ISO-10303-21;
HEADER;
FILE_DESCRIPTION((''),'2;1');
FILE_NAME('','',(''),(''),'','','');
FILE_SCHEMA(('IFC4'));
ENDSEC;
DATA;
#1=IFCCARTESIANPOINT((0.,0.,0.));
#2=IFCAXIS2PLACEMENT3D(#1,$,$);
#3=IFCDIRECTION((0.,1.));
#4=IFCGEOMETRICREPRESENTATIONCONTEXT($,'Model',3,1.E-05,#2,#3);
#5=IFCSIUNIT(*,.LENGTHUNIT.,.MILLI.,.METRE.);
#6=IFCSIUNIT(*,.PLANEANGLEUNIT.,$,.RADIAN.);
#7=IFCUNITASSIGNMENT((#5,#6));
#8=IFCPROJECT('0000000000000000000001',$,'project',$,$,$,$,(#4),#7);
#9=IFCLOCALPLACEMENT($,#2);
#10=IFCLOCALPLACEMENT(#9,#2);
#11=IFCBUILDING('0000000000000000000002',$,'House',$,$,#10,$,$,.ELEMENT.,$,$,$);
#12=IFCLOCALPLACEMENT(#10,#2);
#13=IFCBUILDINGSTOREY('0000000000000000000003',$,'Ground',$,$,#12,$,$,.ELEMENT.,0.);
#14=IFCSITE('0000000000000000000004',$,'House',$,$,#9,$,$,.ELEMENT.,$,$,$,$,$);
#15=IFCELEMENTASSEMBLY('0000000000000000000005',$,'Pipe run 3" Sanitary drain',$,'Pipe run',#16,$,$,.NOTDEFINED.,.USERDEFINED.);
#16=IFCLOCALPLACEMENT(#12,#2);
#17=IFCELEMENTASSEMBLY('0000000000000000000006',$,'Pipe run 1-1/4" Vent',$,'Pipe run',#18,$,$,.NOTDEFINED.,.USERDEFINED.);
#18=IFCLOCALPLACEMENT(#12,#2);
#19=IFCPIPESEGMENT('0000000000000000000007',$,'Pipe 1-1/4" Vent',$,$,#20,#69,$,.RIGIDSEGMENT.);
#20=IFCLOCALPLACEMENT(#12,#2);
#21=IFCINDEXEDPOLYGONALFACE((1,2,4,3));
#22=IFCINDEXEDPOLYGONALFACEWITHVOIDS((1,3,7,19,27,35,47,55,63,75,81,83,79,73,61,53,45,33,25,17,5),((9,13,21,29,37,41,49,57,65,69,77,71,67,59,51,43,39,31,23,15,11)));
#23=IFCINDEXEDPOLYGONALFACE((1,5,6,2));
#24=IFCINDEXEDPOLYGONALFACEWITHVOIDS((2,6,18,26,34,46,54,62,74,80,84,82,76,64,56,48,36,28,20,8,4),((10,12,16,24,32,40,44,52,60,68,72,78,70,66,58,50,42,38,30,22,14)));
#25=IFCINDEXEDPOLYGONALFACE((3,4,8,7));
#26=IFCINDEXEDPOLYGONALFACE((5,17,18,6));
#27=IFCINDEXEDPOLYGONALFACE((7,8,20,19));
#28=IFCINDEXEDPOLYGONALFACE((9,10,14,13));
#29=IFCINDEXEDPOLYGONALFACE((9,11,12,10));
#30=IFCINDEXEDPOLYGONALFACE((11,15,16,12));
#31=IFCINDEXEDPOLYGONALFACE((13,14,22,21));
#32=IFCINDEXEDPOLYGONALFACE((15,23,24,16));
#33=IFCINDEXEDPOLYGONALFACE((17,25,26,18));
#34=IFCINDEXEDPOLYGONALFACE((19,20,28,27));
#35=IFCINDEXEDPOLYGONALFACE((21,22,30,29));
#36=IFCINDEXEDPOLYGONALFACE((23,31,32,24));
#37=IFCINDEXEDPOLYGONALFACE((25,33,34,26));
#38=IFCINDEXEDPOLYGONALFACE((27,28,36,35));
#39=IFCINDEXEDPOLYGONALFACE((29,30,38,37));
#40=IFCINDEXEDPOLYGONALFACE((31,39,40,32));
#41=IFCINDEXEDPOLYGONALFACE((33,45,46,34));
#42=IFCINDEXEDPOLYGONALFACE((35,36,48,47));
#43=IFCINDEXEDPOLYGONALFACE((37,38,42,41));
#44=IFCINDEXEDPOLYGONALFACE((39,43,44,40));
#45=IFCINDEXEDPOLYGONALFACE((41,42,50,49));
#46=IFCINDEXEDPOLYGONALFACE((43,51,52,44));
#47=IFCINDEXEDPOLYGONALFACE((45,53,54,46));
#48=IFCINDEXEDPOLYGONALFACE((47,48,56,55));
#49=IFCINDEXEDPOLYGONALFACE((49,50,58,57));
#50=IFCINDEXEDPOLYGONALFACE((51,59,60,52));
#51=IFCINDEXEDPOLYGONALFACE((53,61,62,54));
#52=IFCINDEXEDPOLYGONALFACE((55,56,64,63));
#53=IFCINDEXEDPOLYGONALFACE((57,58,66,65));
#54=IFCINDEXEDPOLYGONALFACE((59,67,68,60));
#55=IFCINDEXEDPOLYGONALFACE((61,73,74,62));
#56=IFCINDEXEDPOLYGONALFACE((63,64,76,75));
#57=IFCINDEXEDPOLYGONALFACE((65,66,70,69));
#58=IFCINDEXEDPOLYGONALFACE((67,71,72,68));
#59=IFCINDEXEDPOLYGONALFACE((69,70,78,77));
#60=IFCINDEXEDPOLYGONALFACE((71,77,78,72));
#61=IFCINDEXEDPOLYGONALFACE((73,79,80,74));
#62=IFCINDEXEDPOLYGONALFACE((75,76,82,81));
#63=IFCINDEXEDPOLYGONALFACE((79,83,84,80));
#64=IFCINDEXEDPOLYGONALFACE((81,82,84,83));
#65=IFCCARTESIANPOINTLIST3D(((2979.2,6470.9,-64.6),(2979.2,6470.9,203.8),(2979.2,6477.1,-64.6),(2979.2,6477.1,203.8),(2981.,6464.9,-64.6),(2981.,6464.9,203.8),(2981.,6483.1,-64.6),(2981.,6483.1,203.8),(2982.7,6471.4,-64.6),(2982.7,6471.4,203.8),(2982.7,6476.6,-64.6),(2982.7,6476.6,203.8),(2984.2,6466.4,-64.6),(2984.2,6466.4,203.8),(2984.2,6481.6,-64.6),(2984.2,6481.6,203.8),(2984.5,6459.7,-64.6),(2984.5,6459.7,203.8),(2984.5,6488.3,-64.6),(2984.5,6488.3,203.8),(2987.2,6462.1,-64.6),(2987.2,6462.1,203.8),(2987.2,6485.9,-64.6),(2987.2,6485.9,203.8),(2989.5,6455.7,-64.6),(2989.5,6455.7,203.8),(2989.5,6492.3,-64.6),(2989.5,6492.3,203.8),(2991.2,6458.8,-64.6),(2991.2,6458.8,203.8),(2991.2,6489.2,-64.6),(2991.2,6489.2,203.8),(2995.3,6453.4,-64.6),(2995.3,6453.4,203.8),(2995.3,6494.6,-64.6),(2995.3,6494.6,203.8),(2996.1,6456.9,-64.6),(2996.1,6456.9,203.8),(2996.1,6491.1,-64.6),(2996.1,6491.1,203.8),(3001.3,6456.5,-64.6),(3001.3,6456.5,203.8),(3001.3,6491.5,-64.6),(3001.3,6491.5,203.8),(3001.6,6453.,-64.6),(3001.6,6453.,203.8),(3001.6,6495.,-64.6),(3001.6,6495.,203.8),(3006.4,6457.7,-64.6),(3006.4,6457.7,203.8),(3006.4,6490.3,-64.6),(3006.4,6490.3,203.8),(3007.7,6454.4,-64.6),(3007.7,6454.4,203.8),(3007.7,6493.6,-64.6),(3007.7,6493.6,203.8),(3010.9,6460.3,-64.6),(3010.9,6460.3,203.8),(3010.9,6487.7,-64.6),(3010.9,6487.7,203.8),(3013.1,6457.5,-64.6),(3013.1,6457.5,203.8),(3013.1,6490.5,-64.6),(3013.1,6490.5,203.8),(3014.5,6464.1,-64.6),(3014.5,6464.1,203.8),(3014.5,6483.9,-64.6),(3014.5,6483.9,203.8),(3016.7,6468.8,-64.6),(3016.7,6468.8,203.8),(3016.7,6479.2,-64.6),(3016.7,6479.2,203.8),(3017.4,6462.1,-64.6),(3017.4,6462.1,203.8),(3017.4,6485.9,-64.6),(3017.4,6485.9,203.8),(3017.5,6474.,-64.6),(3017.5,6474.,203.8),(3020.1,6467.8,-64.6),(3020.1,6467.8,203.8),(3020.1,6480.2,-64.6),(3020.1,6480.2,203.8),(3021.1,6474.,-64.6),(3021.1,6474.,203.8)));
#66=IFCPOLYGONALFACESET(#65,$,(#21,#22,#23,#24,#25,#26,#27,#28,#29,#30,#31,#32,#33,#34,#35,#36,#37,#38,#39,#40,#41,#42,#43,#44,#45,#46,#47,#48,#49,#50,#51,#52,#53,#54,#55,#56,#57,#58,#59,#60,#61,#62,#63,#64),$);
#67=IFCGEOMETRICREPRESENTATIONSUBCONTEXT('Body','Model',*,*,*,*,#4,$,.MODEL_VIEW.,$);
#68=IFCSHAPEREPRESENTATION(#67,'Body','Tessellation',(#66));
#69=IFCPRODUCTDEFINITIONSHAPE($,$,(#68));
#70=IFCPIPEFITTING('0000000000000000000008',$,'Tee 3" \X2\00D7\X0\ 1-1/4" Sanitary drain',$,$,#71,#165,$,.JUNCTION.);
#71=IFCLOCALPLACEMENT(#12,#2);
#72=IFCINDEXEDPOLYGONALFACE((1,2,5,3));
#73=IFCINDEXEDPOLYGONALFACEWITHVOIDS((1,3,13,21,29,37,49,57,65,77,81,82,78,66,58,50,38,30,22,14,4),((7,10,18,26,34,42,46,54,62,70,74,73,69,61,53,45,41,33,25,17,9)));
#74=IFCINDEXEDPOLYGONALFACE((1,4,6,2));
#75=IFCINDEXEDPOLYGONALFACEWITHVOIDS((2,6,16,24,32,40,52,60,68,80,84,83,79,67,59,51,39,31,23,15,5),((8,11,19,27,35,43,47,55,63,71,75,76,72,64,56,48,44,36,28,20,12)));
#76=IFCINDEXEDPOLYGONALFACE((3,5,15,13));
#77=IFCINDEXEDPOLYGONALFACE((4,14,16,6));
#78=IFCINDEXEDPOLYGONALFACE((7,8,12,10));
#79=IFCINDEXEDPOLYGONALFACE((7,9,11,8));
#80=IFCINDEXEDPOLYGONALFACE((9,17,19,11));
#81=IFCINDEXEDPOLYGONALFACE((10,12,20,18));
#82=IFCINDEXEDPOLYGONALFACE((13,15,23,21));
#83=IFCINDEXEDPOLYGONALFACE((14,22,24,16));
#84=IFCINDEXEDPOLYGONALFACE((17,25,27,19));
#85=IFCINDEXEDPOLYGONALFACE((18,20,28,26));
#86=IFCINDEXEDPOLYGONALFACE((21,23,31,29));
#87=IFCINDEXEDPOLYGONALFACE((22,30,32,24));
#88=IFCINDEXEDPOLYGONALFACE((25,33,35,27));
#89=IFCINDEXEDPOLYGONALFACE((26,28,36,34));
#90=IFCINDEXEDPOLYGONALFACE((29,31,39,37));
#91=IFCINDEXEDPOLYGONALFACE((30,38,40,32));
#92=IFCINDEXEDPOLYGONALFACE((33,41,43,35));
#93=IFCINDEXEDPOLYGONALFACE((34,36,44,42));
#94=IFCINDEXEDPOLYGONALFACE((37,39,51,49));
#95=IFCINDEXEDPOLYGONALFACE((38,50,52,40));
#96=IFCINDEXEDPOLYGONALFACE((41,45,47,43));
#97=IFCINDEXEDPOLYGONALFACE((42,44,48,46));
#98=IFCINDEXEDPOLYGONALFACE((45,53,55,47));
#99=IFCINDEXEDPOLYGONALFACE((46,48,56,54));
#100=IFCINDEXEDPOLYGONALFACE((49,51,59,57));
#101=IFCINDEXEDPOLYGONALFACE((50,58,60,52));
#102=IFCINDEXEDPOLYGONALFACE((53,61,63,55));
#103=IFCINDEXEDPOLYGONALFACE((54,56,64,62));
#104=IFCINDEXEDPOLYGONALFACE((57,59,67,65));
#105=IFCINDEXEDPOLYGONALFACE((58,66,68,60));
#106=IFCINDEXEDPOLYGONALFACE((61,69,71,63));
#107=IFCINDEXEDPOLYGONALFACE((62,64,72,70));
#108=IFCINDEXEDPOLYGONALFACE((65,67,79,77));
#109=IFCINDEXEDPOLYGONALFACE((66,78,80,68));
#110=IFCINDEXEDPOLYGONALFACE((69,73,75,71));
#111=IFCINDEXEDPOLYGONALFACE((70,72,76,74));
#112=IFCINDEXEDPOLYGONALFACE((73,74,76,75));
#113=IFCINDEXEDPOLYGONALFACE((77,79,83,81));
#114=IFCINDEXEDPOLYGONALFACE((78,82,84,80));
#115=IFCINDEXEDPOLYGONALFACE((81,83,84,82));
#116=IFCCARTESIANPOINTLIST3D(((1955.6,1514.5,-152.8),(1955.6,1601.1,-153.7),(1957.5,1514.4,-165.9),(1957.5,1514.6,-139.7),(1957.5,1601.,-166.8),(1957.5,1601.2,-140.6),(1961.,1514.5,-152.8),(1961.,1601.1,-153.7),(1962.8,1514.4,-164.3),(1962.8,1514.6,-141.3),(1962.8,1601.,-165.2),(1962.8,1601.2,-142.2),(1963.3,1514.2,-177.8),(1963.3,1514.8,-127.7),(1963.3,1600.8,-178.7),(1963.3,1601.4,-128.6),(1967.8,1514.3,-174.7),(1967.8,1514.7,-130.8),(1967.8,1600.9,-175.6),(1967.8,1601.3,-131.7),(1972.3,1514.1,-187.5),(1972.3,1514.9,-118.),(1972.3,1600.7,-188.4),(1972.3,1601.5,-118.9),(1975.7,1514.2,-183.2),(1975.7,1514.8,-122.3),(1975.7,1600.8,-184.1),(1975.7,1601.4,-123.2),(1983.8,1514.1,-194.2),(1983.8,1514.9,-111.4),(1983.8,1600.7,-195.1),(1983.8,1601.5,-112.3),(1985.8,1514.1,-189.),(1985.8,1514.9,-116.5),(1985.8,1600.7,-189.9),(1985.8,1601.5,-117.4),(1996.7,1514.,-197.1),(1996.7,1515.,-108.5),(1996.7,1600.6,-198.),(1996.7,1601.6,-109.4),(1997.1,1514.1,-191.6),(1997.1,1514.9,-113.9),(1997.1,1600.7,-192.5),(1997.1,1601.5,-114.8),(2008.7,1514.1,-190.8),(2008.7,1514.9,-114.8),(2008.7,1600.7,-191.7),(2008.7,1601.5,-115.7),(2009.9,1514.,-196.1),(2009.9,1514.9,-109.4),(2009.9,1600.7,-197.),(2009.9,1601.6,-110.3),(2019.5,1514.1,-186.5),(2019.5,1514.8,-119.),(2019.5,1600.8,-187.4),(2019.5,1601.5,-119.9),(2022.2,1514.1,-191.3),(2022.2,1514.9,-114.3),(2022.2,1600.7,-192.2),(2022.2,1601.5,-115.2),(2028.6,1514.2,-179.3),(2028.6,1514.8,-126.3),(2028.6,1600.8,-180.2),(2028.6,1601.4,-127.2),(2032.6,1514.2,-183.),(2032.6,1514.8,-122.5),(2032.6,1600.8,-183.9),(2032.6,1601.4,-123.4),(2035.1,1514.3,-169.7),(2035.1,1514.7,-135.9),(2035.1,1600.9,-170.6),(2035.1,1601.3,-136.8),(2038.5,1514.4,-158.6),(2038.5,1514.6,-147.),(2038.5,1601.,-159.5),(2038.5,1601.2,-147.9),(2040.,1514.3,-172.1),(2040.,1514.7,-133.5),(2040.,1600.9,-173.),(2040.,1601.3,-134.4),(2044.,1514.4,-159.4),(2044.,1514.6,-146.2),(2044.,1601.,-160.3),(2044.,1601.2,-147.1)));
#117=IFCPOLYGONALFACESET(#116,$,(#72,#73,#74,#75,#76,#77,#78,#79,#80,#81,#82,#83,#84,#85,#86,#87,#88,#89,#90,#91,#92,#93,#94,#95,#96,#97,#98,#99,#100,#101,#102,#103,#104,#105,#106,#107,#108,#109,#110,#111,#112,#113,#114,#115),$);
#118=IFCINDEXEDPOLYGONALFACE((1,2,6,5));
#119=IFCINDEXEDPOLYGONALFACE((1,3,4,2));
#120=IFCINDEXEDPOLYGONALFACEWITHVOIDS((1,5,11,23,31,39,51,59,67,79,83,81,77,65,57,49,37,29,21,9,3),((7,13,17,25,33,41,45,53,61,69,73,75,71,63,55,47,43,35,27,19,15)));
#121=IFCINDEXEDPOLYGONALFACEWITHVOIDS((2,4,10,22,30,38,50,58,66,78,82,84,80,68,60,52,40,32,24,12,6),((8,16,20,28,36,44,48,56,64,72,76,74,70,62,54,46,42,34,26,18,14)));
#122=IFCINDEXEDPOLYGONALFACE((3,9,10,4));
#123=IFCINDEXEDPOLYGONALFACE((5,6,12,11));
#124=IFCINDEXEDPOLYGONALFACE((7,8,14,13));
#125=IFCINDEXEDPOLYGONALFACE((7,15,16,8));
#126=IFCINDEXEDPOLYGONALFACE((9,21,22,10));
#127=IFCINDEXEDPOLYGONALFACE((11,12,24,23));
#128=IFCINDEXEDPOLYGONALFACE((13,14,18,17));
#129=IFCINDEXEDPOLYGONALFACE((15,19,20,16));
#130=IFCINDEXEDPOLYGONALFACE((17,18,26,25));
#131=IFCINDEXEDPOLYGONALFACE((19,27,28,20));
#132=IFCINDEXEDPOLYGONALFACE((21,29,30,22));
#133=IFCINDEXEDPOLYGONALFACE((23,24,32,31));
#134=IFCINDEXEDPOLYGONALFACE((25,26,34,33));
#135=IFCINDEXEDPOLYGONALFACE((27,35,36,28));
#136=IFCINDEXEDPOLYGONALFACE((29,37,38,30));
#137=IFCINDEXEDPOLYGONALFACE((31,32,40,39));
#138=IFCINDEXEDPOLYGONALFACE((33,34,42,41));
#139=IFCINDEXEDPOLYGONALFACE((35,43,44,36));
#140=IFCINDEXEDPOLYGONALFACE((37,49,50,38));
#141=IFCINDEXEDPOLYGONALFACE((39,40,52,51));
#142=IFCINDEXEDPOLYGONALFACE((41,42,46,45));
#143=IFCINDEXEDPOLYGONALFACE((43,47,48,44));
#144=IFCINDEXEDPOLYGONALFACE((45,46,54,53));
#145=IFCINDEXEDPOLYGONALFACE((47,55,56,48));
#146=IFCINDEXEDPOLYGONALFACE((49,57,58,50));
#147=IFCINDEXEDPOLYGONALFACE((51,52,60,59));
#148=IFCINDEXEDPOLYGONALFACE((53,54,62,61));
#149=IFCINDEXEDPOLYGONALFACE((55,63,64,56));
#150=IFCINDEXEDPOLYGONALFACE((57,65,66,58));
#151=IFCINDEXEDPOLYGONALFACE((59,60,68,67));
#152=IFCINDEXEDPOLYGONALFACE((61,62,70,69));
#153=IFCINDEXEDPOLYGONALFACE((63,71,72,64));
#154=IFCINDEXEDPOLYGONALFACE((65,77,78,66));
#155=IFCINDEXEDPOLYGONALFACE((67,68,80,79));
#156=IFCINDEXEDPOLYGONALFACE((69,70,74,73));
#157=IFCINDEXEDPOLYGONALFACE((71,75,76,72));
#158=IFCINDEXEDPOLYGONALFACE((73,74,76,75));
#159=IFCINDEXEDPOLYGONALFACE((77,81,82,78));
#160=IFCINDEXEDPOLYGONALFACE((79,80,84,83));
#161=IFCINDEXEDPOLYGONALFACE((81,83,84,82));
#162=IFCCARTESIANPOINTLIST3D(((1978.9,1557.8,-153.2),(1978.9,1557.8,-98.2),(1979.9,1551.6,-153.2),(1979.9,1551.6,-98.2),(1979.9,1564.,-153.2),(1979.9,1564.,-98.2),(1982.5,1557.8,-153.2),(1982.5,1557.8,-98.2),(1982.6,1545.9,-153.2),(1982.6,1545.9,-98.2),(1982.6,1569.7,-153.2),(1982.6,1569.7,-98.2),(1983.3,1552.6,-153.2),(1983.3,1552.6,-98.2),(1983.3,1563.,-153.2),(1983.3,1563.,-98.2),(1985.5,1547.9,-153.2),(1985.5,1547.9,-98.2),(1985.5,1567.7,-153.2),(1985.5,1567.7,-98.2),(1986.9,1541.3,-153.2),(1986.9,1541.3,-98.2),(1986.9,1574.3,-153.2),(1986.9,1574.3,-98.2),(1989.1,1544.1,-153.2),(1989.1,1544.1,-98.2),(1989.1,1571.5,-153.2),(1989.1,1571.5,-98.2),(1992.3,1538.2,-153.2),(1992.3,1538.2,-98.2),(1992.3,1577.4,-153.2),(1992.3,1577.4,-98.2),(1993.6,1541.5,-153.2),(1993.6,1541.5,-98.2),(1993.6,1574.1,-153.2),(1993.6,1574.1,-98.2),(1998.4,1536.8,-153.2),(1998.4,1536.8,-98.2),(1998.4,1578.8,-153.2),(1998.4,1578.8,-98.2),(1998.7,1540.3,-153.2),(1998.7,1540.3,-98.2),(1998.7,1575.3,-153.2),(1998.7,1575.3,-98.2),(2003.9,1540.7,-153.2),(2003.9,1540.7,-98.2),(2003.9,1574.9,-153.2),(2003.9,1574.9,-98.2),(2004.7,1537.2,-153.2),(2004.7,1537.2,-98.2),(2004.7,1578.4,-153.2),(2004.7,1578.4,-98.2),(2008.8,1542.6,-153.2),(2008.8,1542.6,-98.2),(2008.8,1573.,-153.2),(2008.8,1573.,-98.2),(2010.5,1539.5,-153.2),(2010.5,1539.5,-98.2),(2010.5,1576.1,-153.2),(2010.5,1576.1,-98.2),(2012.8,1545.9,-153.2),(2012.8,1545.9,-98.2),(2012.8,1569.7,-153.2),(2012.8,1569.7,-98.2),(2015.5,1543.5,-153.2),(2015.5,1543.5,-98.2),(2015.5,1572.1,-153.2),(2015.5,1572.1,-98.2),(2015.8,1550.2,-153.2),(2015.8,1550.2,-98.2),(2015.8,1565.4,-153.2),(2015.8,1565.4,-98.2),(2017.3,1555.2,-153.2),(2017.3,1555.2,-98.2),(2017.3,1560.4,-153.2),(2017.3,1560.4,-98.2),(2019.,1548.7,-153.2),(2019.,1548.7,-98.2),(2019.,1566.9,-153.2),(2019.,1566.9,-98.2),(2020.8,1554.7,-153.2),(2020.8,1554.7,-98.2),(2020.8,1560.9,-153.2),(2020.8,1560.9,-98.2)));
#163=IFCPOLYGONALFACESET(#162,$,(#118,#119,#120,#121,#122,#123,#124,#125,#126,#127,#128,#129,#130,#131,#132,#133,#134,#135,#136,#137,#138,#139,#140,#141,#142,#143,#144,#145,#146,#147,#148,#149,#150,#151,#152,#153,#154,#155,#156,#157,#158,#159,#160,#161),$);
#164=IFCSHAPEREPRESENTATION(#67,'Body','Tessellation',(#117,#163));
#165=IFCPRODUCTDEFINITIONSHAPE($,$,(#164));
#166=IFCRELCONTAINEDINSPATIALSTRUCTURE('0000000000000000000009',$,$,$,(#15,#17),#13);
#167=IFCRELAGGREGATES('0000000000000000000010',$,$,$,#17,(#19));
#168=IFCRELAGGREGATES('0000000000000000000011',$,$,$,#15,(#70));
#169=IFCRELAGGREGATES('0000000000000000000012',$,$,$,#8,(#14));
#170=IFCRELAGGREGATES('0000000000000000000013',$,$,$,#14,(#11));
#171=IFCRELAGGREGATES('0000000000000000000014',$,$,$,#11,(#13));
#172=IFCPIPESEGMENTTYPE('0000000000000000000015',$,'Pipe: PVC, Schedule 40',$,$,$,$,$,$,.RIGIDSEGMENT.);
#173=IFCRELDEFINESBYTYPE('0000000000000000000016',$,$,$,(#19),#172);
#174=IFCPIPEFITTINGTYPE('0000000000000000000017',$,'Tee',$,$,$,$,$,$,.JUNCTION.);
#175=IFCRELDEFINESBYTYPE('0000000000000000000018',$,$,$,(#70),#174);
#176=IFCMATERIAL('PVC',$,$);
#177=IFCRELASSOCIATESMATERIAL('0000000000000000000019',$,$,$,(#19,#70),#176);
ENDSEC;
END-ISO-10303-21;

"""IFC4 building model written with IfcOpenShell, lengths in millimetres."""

from ifc_helpers import new_model, si_unit, direction, frame, origin, origin_with_axes, origin_2d, place, context, subcontext, project, spatial, hollow_circle, extrude, material, type_object, element, aggregate, save


model = new_model("IFC4")

# Units and contexts
model_context = context("Model", 3, precision=1e-05, world=origin(), true_north=direction((0.0, 1.0)))
body_context = subcontext(model_context, "Body", "Model", "MODEL_VIEW")
ifc_project = project(units=[si_unit("LENGTHUNIT", "METRE", prefix="MILLI"), si_unit("PLANEANGLEUNIT", "RADIAN")], contexts=[model_context])

# Site, building, storey
site_placement = place(None, origin())
site = spatial("IfcSite", under=ifc_project, at=site_placement, Name="House", CompositionType="ELEMENT")
building_placement = place(site_placement, origin())
building = spatial("IfcBuilding", under=site, at=building_placement, Name="House", CompositionType="ELEMENT")
storey_placement = place(building_placement, origin())
storey = spatial("IfcBuildingStorey", under=building, at=storey_placement, Name="Ground", CompositionType="ELEMENT", Elevation=0.0)

# Element assembly
assembly_1_placement = place(storey_placement, origin_with_axes())
assembly_1 = element("IfcElementAssembly", 1, at=assembly_1_placement, inside=storey, Name="Pipe run 3\" Sanitary drain", ObjectType="Pipe run", AssemblyPlace="NOTDEFINED", PredefinedType="USERDEFINED")
ifc_material = material(Name="PVC")
pipe_segment_type = type_object("IfcPipeSegmentType", Name="Pipe: PVC, Schedule 40", PredefinedType="RIGIDSEGMENT")

# Element assembly, pipe segment
assembly_2_placement = place(storey_placement, origin_with_axes())
assembly_2 = element("IfcElementAssembly", 2, at=assembly_2_placement, inside=storey, Name="Pipe run 1-1/4\" Vent", ObjectType="Pipe run", AssemblyPlace="NOTDEFINED", PredefinedType="USERDEFINED")
pipe_segment_1_placement = place(storey_placement, origin_with_axes())
pipe_segment_1 = element("IfcPipeSegment", 3, at=pipe_segment_1_placement, type_object=pipe_segment_type, material=ifc_material, Name="Pipe 1-1/4\" Vent", PredefinedType="RIGIDSEGMENT", context=body_context, shape_type="SweptSolid", body=[
    extrude(hollow_circle(Radius=21.1, WallThickness=3.6, at=origin_2d()), frame((3000.0, 6474.0, 203.8), z_axis=(0.0, 0.0, -1.0), x_axis=(1.0, 0.0, 0.0)), (0.0, 0.0, 1.0), 268.4),
])
aggregate(assembly_2, [pipe_segment_1])

# Pipe fitting
pipe_fitting_type_1 = type_object("IfcPipeFittingType", Name="Tee", PredefinedType="JUNCTION")
pipe_fitting_1_placement = place(storey_placement, origin_with_axes())
pipe_fitting_1 = element("IfcPipeFitting", 4, at=pipe_fitting_1_placement, type_object=pipe_fitting_type_1, material=ifc_material, Name="Tee 3\" × 1-1/4\" Sanitary drain", PredefinedType="JUNCTION", context=body_context, shape_type="SweptSolid", body=[
    extrude(hollow_circle(Radius=44.5, WallThickness=5.5, at=origin_2d()), frame((2000.0, 1514.5, -152.8), z_axis=(0.0, 0.999946, -0.010416), x_axis=(-1.0, 0.0, 0.0)), (0.0, 0.0, 1.0), 86.6),
    extrude(hollow_circle(Radius=21.1, WallThickness=3.6, at=origin_2d()), frame((2000.0, 1557.8, -153.2), z_axis=(0.0, 0.0, 1.0), x_axis=(-1.0, 0.0, 0.0)), (0.0, 0.0, 1.0), 55.0),
])
aggregate(assembly_1, [pipe_fitting_1])

save(model, "model.ifc")
